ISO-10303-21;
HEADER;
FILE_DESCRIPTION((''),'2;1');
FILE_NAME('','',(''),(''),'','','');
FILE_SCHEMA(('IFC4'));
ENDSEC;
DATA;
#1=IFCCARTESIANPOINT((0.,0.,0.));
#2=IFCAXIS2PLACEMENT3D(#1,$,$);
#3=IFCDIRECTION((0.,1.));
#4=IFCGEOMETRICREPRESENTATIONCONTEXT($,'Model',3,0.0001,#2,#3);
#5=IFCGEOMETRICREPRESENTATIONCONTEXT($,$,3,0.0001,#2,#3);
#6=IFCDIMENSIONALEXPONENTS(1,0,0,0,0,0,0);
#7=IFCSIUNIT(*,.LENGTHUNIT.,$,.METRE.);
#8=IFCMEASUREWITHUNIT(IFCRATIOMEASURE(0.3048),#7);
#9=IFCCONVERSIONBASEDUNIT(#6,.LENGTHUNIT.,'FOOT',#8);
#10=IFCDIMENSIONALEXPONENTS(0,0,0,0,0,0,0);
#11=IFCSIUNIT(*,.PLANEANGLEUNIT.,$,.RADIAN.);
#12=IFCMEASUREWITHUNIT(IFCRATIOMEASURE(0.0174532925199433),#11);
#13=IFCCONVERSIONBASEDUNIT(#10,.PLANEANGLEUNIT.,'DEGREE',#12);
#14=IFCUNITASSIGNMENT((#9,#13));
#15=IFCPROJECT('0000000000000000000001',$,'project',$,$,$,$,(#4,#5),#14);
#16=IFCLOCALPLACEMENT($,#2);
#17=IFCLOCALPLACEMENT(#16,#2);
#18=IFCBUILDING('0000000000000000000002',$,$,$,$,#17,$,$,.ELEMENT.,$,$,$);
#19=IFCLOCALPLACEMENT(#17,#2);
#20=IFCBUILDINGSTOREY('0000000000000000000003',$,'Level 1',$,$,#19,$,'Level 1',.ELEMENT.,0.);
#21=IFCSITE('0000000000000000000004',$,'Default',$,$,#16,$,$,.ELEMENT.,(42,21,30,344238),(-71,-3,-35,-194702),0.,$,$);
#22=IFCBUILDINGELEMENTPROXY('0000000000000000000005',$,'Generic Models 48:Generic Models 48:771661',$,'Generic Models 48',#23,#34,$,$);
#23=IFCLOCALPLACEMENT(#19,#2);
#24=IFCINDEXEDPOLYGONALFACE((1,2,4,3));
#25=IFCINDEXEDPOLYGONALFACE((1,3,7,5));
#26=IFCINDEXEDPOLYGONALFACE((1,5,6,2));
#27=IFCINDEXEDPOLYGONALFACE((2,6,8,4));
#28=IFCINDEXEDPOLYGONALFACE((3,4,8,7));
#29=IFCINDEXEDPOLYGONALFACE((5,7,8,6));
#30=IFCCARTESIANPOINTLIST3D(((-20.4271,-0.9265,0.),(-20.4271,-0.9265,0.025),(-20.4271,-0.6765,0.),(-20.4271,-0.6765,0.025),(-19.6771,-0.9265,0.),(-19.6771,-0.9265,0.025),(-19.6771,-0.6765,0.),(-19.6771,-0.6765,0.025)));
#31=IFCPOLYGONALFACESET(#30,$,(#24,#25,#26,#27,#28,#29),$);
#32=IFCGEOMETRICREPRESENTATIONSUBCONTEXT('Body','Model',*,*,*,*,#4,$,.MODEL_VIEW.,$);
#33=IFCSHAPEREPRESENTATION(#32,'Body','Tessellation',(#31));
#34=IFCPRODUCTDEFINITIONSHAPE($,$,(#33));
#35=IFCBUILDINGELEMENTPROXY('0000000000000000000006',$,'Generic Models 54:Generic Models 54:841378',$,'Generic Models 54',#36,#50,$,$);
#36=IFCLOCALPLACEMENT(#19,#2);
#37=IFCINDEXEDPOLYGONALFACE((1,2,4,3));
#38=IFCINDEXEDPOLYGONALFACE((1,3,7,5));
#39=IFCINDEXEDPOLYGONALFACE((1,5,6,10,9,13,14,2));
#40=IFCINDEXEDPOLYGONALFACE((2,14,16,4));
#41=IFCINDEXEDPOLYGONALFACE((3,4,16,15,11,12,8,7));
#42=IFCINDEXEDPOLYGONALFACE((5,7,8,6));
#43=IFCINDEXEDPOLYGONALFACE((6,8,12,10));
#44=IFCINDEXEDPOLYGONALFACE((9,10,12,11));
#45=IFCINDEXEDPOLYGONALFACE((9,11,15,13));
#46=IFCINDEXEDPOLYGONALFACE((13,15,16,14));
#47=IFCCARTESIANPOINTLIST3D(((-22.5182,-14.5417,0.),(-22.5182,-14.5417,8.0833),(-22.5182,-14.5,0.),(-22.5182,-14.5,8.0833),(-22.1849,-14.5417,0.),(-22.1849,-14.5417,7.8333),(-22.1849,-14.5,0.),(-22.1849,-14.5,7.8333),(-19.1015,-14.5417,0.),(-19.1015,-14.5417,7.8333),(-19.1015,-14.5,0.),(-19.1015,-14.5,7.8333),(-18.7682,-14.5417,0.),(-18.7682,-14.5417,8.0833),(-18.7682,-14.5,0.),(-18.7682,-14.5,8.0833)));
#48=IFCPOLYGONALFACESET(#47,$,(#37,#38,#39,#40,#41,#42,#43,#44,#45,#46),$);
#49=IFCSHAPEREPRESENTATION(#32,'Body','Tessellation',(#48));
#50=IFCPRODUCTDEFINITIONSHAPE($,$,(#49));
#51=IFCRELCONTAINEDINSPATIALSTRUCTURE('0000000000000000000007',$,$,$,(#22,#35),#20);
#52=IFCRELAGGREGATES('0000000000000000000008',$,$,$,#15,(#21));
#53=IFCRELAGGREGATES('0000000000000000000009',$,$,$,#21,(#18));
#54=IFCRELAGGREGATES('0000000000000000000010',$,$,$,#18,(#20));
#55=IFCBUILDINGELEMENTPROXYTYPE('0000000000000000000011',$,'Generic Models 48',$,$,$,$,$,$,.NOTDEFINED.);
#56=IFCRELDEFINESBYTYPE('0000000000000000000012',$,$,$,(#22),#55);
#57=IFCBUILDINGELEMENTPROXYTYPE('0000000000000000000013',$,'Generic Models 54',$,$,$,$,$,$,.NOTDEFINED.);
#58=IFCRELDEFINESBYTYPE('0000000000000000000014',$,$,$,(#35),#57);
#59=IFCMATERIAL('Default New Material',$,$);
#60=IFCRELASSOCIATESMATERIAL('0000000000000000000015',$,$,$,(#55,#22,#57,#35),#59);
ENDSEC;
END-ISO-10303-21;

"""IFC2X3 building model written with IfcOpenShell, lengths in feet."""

from ifc_helpers import new_model, entity, si_unit, converted_unit, direction, frame, origin, origin_2d_with_axis, place, context, subcontext, project, spatial, polyline, rectangle, outline, extrude, source, transform, mapped, material, type_object, type_shapes, element, save


model = new_model("IFC2X3")

# Units and contexts
model_context = context("Model", 3, precision=0.0001, world=origin(), true_north=direction((0.0, 1.0)))
context_of_model = context(None, 3, precision=0.0001, world=origin(), true_north=direction((0.0, 1.0)))
body_context = subcontext(model_context, "Body", "Model", "MODEL_VIEW")
ifc_project = project(units=[converted_unit("LENGTHUNIT", "FOOT", entity("IfcRatioMeasure", 0.3048), si_unit("LENGTHUNIT", "METRE"), dimensions=[1, 0, 0, 0, 0, 0, 0]), converted_unit("PLANEANGLEUNIT", "DEGREE", entity("IfcRatioMeasure", 0.0174532925199433), si_unit("PLANEANGLEUNIT", "RADIAN"), dimensions=[0, 0, 0, 0, 0, 0, 0])], contexts=[model_context, context_of_model])

# Site, building, storey
site_placement = place(None, origin())
site = spatial("IfcSite", under=ifc_project, at=site_placement, Name="Default", CompositionType="ELEMENT", RefLatitude=(42, 21, 30, 344238), RefLongitude=(-71, -3, -35, -194702), RefElevation=0.0)
building_placement = place(site_placement, origin())
building = spatial("IfcBuilding", under=site, at=building_placement, CompositionType="ELEMENT")
storey_placement = place(building_placement, origin())
storey = spatial("IfcBuildingStorey", under=building, at=storey_placement, Name="Level 1", LongName="Level 1", CompositionType="ELEMENT", Elevation=0.0)

# Shared definitions
ifc_material = material(Name="Default New Material")

# Building element proxies
building_element_proxy_type_1 = type_object("IfcBuildingElementProxyType", Name="Generic Models 48", PredefinedType="NOTDEFINED", material=ifc_material)
shared_shape_1 = source(origin(), body_context, "Body", "SweptSolid", [
    extrude(rectangle(XDim=0.75, YDim=0.25, at=origin_2d_with_axis()), frame((0.375, 0.125, 0.0)), (0.0, 0.0, 1.0), 0.025),
])
type_shapes(building_element_proxy_type_1, [shared_shape_1])
proxy_1_placement = place(storey_placement, frame((-20.4271, -0.9265, 0.0)))
element("IfcBuildingElementProxy", 1, at=proxy_1_placement, inside=storey, type_object=building_element_proxy_type_1, material=ifc_material, Name="Generic Models 48:Generic Models 48:771661", ObjectType="Generic Models 48", context=body_context, shape_type="MappedRepresentation", body=[
    mapped(shared_shape_1, transform((0.0, 0.0, 0.0), scale=1.0)),
])
building_element_proxy_type_2 = type_object("IfcBuildingElementProxyType", Name="Generic Models 54", PredefinedType="NOTDEFINED", material=ifc_material)
shared_shape_2 = source(origin(), body_context, "Body", "SweptSolid", [
    extrude(outline(polyline([(-3.8542, 1.5417), (3.9792, 1.5417), (3.9792, 1.875), (-4.1042, 1.875), (-4.1042, -1.875), (3.9792, -1.875), (3.9792, -1.5417), (-3.8542, -1.5417), (-3.8542, 1.5417)])), frame((1.875, 0.0, 3.9792), z_axis=(0.0, 1.0, 0.0), x_axis=(0.0, 0.0, -1.0)), (0.0, 0.0, 1.0), 0.0417),
])
type_shapes(building_element_proxy_type_2, [shared_shape_2])
proxy_2_placement = place(storey_placement, frame((-22.5182, -14.5417, 0.0)))
element("IfcBuildingElementProxy", 2, at=proxy_2_placement, inside=storey, type_object=building_element_proxy_type_2, material=ifc_material, Name="Generic Models 54:Generic Models 54:841378", ObjectType="Generic Models 54", context=body_context, shape_type="MappedRepresentation", body=[
    mapped(shared_shape_2, transform((0.0, 0.0, 0.0), scale=1.0)),
])

save(model, "model.ifc")
